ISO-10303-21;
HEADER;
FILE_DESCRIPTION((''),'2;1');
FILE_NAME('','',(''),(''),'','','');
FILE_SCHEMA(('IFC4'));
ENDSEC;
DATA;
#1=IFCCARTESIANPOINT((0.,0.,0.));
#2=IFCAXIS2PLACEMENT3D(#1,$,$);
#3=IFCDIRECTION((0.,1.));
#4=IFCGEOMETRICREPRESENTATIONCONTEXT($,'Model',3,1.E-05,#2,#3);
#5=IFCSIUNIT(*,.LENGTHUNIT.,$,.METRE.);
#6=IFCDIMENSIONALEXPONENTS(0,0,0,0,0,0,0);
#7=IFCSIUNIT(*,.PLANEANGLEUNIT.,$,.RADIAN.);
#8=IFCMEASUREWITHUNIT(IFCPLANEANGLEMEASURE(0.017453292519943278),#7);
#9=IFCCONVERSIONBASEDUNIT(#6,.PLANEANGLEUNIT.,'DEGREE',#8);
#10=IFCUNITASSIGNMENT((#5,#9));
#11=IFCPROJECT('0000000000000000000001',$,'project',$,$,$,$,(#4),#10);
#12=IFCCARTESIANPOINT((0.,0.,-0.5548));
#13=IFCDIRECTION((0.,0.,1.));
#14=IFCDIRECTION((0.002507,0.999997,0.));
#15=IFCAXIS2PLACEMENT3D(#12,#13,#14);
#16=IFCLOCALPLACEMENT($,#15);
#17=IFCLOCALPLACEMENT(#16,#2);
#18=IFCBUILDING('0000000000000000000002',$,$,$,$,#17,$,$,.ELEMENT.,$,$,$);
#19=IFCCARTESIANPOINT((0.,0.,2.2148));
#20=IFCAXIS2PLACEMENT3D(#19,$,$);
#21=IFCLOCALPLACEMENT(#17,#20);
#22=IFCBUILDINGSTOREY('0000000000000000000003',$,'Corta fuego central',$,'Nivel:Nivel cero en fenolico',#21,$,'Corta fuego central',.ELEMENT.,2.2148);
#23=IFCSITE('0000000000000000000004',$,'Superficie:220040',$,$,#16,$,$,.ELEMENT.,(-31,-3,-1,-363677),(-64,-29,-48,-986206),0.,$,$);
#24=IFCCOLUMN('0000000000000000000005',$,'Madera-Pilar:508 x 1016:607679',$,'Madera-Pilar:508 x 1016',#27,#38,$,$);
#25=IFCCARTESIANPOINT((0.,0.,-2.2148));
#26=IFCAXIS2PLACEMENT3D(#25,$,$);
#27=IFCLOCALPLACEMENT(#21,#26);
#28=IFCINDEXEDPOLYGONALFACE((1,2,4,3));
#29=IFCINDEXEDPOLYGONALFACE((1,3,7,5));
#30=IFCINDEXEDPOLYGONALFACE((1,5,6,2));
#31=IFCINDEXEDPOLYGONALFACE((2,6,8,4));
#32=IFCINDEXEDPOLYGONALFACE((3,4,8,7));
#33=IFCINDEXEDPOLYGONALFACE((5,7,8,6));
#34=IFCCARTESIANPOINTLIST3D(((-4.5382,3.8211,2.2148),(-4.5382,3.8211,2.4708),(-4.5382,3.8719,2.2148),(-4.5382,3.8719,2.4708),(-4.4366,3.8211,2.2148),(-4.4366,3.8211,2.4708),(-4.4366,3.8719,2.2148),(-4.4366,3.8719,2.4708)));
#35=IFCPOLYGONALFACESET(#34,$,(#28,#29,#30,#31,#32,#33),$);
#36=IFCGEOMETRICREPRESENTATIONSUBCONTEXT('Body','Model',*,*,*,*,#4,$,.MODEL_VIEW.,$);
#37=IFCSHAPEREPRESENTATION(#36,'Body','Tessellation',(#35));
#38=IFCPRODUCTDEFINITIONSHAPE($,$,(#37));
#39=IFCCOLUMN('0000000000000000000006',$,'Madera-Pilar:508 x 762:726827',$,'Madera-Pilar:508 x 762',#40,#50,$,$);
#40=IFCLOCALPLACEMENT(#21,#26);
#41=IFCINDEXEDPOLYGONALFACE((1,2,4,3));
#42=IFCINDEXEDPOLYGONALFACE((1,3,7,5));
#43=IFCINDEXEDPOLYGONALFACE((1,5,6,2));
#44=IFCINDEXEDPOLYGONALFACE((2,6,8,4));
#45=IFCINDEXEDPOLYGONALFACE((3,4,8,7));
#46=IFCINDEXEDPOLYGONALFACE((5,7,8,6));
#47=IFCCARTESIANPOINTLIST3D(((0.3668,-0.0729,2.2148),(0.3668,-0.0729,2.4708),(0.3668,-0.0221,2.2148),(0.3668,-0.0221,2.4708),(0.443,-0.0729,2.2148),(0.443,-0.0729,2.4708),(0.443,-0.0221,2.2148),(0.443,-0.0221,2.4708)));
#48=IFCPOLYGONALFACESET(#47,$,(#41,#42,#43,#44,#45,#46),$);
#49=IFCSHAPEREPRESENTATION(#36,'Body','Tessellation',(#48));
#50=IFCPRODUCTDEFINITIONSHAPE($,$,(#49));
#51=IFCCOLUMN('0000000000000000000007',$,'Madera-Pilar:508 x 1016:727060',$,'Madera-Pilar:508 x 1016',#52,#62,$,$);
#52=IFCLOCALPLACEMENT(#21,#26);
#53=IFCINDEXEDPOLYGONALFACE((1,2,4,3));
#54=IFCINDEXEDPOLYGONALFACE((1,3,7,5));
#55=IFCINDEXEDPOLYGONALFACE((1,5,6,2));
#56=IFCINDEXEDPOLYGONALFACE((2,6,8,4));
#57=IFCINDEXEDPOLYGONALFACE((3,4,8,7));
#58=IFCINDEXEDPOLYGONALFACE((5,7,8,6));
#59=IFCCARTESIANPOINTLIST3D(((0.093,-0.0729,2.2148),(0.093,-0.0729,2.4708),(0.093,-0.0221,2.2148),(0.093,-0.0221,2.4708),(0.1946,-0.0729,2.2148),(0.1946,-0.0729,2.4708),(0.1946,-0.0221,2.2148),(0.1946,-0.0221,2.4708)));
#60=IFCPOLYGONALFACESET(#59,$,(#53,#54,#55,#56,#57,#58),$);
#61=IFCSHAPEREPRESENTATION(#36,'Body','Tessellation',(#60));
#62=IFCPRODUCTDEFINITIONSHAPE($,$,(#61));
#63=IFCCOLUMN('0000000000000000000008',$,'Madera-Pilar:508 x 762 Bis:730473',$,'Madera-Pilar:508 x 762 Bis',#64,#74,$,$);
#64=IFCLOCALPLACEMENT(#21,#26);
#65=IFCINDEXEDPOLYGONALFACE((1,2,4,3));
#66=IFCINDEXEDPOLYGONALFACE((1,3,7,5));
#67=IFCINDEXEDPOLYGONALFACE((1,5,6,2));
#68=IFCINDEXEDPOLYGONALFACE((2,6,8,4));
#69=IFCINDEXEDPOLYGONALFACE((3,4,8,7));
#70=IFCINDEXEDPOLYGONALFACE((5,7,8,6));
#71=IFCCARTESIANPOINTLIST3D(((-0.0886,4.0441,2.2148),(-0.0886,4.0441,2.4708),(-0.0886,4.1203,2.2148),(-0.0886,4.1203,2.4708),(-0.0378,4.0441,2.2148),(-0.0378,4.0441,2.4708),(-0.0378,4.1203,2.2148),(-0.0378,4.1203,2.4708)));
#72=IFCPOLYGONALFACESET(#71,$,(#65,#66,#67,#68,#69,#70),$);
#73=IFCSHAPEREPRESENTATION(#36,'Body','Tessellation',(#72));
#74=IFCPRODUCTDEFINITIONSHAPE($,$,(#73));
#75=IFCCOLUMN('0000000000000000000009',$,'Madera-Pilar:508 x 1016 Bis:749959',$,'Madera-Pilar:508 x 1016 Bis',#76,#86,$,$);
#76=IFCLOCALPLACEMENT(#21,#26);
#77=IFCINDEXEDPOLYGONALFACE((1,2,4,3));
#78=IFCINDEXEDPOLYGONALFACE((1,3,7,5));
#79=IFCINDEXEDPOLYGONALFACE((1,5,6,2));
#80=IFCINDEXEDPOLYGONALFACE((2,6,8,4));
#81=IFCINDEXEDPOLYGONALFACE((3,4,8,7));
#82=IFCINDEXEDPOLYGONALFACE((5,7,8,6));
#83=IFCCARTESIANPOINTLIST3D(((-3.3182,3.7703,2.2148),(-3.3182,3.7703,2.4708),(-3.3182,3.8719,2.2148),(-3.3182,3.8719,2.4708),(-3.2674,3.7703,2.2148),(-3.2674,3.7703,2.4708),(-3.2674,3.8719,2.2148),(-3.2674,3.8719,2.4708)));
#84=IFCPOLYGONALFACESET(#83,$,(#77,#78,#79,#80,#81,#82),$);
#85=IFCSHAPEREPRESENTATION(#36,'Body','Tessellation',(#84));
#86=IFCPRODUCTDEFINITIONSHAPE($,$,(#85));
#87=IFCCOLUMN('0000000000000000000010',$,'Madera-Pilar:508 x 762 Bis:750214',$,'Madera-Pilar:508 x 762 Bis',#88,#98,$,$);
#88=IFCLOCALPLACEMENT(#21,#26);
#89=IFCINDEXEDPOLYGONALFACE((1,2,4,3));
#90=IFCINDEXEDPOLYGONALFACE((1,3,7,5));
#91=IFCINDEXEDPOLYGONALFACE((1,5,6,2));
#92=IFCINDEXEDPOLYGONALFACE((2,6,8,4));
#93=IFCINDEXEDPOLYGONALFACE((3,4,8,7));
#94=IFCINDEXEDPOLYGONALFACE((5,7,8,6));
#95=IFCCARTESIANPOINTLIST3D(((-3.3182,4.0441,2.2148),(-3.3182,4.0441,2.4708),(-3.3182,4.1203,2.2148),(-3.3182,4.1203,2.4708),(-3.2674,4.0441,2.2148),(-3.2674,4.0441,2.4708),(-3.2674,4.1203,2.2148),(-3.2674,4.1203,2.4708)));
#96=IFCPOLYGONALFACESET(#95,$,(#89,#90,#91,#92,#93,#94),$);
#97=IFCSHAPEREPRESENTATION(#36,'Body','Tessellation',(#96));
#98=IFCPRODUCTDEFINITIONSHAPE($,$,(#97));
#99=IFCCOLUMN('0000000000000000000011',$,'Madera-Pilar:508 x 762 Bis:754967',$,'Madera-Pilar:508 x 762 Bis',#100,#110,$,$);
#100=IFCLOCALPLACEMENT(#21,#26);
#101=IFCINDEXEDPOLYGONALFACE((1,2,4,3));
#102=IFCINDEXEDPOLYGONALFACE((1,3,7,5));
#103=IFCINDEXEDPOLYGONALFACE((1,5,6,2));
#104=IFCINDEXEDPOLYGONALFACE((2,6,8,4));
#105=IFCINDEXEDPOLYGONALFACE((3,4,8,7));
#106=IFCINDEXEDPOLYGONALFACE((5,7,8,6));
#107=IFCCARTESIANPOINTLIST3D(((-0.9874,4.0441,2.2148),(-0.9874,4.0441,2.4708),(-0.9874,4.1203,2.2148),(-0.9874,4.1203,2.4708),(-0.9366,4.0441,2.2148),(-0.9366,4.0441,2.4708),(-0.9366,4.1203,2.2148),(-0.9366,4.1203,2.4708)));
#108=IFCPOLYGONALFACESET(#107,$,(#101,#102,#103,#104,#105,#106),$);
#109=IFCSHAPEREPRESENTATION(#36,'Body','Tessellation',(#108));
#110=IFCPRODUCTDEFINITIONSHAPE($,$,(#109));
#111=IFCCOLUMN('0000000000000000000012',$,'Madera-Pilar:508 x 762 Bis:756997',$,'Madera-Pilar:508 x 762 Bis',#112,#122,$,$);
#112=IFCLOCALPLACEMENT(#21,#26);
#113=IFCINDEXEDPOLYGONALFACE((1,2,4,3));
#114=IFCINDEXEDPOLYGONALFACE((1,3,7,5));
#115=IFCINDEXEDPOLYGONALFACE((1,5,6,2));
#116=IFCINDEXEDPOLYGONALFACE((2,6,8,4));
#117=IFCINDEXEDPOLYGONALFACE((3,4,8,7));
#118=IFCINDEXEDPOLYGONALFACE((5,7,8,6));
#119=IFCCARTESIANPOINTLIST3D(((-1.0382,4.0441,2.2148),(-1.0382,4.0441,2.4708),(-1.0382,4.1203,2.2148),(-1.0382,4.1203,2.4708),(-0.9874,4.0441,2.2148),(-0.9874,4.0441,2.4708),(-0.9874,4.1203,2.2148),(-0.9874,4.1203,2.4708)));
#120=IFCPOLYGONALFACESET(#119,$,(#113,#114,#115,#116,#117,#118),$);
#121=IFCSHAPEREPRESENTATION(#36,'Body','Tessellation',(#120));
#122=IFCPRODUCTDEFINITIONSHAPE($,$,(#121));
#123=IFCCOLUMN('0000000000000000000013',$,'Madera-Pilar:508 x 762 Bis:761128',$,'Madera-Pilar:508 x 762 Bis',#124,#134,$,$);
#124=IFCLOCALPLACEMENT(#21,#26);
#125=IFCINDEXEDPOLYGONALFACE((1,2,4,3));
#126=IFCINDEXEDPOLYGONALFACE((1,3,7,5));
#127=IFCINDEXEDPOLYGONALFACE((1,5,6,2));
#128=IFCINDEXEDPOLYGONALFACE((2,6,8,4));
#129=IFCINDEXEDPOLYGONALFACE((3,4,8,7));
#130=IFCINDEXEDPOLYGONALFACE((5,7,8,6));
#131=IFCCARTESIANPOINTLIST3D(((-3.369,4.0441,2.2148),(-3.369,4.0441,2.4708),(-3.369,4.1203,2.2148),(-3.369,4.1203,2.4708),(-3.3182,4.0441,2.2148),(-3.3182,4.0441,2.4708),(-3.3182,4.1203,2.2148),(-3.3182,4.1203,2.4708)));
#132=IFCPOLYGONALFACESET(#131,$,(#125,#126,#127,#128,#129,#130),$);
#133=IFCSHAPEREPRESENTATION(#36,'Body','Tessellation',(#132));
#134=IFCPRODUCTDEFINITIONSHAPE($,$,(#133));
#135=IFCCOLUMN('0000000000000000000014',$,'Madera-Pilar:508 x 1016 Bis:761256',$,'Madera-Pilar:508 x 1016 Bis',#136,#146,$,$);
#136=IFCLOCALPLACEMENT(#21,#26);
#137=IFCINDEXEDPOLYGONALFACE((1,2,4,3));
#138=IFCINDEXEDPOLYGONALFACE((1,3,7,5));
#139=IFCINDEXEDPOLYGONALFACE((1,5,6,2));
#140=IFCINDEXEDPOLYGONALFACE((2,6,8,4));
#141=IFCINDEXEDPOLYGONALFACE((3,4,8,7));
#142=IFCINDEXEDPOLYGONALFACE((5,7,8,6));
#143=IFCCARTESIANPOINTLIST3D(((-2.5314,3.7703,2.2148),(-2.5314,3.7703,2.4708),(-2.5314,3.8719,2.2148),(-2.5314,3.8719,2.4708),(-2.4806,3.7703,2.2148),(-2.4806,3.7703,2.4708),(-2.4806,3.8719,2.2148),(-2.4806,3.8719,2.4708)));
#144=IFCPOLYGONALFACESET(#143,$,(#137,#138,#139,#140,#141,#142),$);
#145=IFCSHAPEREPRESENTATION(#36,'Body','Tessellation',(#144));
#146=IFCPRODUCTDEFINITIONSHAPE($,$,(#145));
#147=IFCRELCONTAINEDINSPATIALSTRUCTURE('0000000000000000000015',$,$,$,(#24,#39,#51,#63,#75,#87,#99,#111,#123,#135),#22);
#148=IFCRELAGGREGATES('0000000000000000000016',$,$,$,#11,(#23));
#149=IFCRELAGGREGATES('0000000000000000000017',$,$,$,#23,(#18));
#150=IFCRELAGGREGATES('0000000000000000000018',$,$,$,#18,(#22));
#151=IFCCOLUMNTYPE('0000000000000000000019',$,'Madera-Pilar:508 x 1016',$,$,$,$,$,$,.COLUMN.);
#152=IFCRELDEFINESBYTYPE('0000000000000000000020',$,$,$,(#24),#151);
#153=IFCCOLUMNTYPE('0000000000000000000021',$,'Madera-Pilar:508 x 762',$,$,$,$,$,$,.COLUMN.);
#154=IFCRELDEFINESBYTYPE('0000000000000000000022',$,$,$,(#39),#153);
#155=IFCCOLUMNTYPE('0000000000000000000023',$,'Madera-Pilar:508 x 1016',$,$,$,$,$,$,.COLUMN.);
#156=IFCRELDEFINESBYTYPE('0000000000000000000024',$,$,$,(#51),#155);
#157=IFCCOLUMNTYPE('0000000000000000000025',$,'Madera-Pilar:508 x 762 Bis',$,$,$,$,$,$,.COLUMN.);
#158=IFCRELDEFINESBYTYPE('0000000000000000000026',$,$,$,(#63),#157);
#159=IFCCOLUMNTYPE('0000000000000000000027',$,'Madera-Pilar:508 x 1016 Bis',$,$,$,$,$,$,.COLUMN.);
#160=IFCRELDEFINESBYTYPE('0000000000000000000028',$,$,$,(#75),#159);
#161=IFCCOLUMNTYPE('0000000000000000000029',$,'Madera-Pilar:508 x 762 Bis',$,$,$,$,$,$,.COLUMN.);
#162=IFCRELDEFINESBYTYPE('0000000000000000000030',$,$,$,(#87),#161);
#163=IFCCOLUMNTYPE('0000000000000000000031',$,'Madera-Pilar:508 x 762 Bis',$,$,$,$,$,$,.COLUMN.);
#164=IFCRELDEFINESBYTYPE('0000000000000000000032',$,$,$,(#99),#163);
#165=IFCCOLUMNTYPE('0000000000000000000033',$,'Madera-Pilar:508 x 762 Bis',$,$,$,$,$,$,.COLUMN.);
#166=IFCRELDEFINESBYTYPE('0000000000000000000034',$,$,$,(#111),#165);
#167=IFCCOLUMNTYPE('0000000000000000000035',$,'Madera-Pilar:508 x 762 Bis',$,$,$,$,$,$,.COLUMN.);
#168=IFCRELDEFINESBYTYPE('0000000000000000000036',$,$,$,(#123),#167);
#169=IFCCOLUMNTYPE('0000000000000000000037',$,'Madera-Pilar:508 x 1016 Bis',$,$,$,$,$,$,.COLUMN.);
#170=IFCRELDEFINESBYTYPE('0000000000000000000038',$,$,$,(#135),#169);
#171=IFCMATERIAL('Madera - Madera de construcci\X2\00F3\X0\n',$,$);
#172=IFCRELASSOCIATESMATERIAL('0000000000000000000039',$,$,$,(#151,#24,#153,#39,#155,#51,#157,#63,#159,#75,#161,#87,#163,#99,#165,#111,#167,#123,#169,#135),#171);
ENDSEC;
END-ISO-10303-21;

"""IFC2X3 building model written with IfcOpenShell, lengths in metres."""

from ifc_helpers import new_model, entity, si_unit, converted_unit, direction, frame, frame_2d, origin, place, context, subcontext, project, spatial, rectangle, extrude, source, transform, mapped, material, type_object, type_shapes, element, save


model = new_model("IFC2X3")

# Units and contexts
model_context = context("Model", 3, precision=1e-05, world=origin(), true_north=direction((0.0, 1.0)))
body_context = subcontext(model_context, "Body", "Model", "MODEL_VIEW")
ifc_project = project(units=[si_unit("LENGTHUNIT", "METRE"), converted_unit("PLANEANGLEUNIT", "DEGREE", entity("IfcPlaneAngleMeasure", 0.017453292519943278), si_unit("PLANEANGLEUNIT", "RADIAN"), dimensions=[0, 0, 0, 0, 0, 0, 0])], contexts=[model_context])

# Site, building, storey
site_placement = place(None, frame((0.0, 0.0, -0.5548), z_axis=(0.0, 0.0, 1.0), x_axis=(0.002507, 0.999997, 0.0)))
site = spatial("IfcSite", under=ifc_project, at=site_placement, Name="Superficie:220040", CompositionType="ELEMENT", RefLatitude=(-31, -3, -1, -363677), RefLongitude=(-64, -29, -48, -986206), RefElevation=0.0)
building_placement = place(site_placement, origin())
building = spatial("IfcBuilding", under=site, at=building_placement, CompositionType="ELEMENT")
storey_placement = place(building_placement, frame((0.0, 0.0, 2.2148)))
storey = spatial("IfcBuildingStorey", under=building, at=storey_placement, Name="Corta fuego central", ObjectType="Nivel:Nivel cero en fenolico", LongName="Corta fuego central", CompositionType="ELEMENT", Elevation=2.2148)

# Columns
ifc_material = material(Name="Madera - Madera de construcción")
column_type_1 = type_object("IfcColumnType", Name="Madera-Pilar:508 x 1016", PredefinedType="COLUMN", material=ifc_material)
shared_shape_1 = source(origin(), body_context, "Body", "SweptSolid", [
    extrude(rectangle(XDim=0.1016, YDim=0.0508, at=frame_2d((0.0, 0.0), x_axis=(1.0, 0.0))), frame((-4.4874, 3.8465, 2.2148), z_axis=(0.0, 0.0, 1.0), x_axis=(-1.0, 0.0, 0.0)), (0.0, 0.0, 1.0), 0.256),
])
type_shapes(column_type_1, [shared_shape_1])
column_1_placement = place(storey_placement, frame((0.0, 0.0, -2.2148)))
element("IfcColumn", 1, at=column_1_placement, inside=storey, type_object=column_type_1, material=ifc_material, Name="Madera-Pilar:508 x 1016:607679", ObjectType="Madera-Pilar:508 x 1016", context=body_context, shape_type="MappedRepresentation", body=[
    mapped(shared_shape_1, transform((0.0, 0.0, 0.0), scale=1.0)),
])
column_type_2 = type_object("IfcColumnType", Name="Madera-Pilar:508 x 762", PredefinedType="COLUMN", material=ifc_material)
shared_shape_2 = source(origin(), body_context, "Body", "SweptSolid", [
    extrude(rectangle(XDim=0.0762, YDim=0.0508, at=frame_2d((0.0, 0.0), x_axis=(1.0, 0.0))), frame((0.4049, -0.0475, 2.2148), z_axis=(0.0, 0.0, 1.0), x_axis=(-1.0, 0.0, 0.0)), (0.0, 0.0, 1.0), 0.256),
])
type_shapes(column_type_2, [shared_shape_2])
column_2_placement = place(storey_placement, frame((0.0, 0.0, -2.2148)))
element("IfcColumn", 2, at=column_2_placement, inside=storey, type_object=column_type_2, material=ifc_material, Name="Madera-Pilar:508 x 762:726827", ObjectType="Madera-Pilar:508 x 762", context=body_context, shape_type="MappedRepresentation", body=[
    mapped(shared_shape_2, transform((0.0, 0.0, 0.0), scale=1.0)),
])
column_type_3 = type_object("IfcColumnType", Name="Madera-Pilar:508 x 1016", PredefinedType="COLUMN", material=ifc_material)
shared_shape_3 = source(origin(), body_context, "Body", "SweptSolid", [
    extrude(rectangle(XDim=0.1016, YDim=0.0508, at=frame_2d((0.0, 0.0), x_axis=(1.0, 0.0))), frame((0.1438, -0.0475, 2.2148), z_axis=(0.0, 0.0, 1.0), x_axis=(-1.0, 0.0, 0.0)), (0.0, 0.0, 1.0), 0.256),
])
type_shapes(column_type_3, [shared_shape_3])
column_3_placement = place(storey_placement, frame((0.0, 0.0, -2.2148)))
element("IfcColumn", 3, at=column_3_placement, inside=storey, type_object=column_type_3, material=ifc_material, Name="Madera-Pilar:508 x 1016:727060", ObjectType="Madera-Pilar:508 x 1016", context=body_context, shape_type="MappedRepresentation", body=[
    mapped(shared_shape_3, transform((0.0, 0.0, 0.0), scale=1.0)),
])
column_type_4 = type_object("IfcColumnType", Name="Madera-Pilar:508 x 762 Bis", PredefinedType="COLUMN", material=ifc_material)
shared_shape_4 = source(origin(), body_context, "Body", "SweptSolid", [
    extrude(rectangle(XDim=0.0508, YDim=0.0762, at=frame_2d((0.0, 0.0), x_axis=(1.0, 0.0))), frame((-0.0632, 4.0822, 2.2148), z_axis=(0.0, 0.0, 1.0), x_axis=(-1.0, 0.0, 0.0)), (0.0, 0.0, 1.0), 0.256),
])
type_shapes(column_type_4, [shared_shape_4])
column_4_placement = place(storey_placement, frame((0.0, 0.0, -2.2148)))
element("IfcColumn", 4, at=column_4_placement, inside=storey, type_object=column_type_4, material=ifc_material, Name="Madera-Pilar:508 x 762 Bis:730473", ObjectType="Madera-Pilar:508 x 762 Bis", context=body_context, shape_type="MappedRepresentation", body=[
    mapped(shared_shape_4, transform((0.0, 0.0, 0.0), scale=1.0)),
])
column_type_5 = type_object("IfcColumnType", Name="Madera-Pilar:508 x 1016 Bis", PredefinedType="COLUMN", material=ifc_material)
shared_shape_5 = source(origin(), body_context, "Body", "SweptSolid", [
    extrude(rectangle(XDim=0.0508, YDim=0.1016, at=frame_2d((0.0, 0.0), x_axis=(1.0, 0.0))), frame((-3.2928, 3.8211, 2.2148), z_axis=(0.0, 0.0, 1.0), x_axis=(-1.0, 0.0, 0.0)), (0.0, 0.0, 1.0), 0.256),
])
type_shapes(column_type_5, [shared_shape_5])
column_5_placement = place(storey_placement, frame((0.0, 0.0, -2.2148)))
element("IfcColumn", 5, at=column_5_placement, inside=storey, type_object=column_type_5, material=ifc_material, Name="Madera-Pilar:508 x 1016 Bis:749959", ObjectType="Madera-Pilar:508 x 1016 Bis", context=body_context, shape_type="MappedRepresentation", body=[
    mapped(shared_shape_5, transform((0.0, 0.0, 0.0), scale=1.0)),
])
column_type_6 = type_object("IfcColumnType", Name="Madera-Pilar:508 x 762 Bis", PredefinedType="COLUMN", material=ifc_material)
shared_shape_6 = source(origin(), body_context, "Body", "SweptSolid", [
    extrude(rectangle(XDim=0.0508, YDim=0.0762, at=frame_2d((0.0, 0.0), x_axis=(1.0, 0.0))), frame((-3.2928, 4.0822, 2.2148), z_axis=(0.0, 0.0, 1.0), x_axis=(-1.0, 0.0, 0.0)), (0.0, 0.0, 1.0), 0.256),
])
type_shapes(column_type_6, [shared_shape_6])
column_6_placement = place(storey_placement, frame((0.0, 0.0, -2.2148)))
element("IfcColumn", 6, at=column_6_placement, inside=storey, type_object=column_type_6, material=ifc_material, Name="Madera-Pilar:508 x 762 Bis:750214", ObjectType="Madera-Pilar:508 x 762 Bis", context=body_context, shape_type="MappedRepresentation", body=[
    mapped(shared_shape_6, transform((0.0, 0.0, 0.0), scale=1.0)),
])
column_type_7 = type_object("IfcColumnType", Name="Madera-Pilar:508 x 762 Bis", PredefinedType="COLUMN", material=ifc_material)
shared_shape_7 = source(origin(), body_context, "Body", "SweptSolid", [
    extrude(rectangle(XDim=0.0508, YDim=0.0762, at=frame_2d((0.0, 0.0), x_axis=(1.0, 0.0))), frame((-0.962, 4.0822, 2.2148), z_axis=(0.0, 0.0, 1.0), x_axis=(-1.0, 0.0, 0.0)), (0.0, 0.0, 1.0), 0.256),
])
type_shapes(column_type_7, [shared_shape_7])
column_7_placement = place(storey_placement, frame((0.0, 0.0, -2.2148)))
element("IfcColumn", 7, at=column_7_placement, inside=storey, type_object=column_type_7, material=ifc_material, Name="Madera-Pilar:508 x 762 Bis:754967", ObjectType="Madera-Pilar:508 x 762 Bis", context=body_context, shape_type="MappedRepresentation", body=[
    mapped(shared_shape_7, transform((0.0, 0.0, 0.0), scale=1.0)),
])
column_type_8 = type_object("IfcColumnType", Name="Madera-Pilar:508 x 762 Bis", PredefinedType="COLUMN", material=ifc_material)
shared_shape_8 = source(origin(), body_context, "Body", "SweptSolid", [
    extrude(rectangle(XDim=0.0508, YDim=0.0762, at=frame_2d((0.0, 0.0), x_axis=(1.0, 0.0))), frame((-1.0128, 4.0822, 2.2148), z_axis=(0.0, 0.0, 1.0), x_axis=(-1.0, 0.0, 0.0)), (0.0, 0.0, 1.0), 0.256),
])
type_shapes(column_type_8, [shared_shape_8])
column_8_placement = place(storey_placement, frame((0.0, 0.0, -2.2148)))
element("IfcColumn", 8, at=column_8_placement, inside=storey, type_object=column_type_8, material=ifc_material, Name="Madera-Pilar:508 x 762 Bis:756997", ObjectType="Madera-Pilar:508 x 762 Bis", context=body_context, shape_type="MappedRepresentation", body=[
    mapped(shared_shape_8, transform((0.0, 0.0, 0.0), scale=1.0)),
])
column_type_9 = type_object("IfcColumnType", Name="Madera-Pilar:508 x 762 Bis", PredefinedType="COLUMN", material=ifc_material)
shared_shape_9 = source(origin(), body_context, "Body", "SweptSolid", [
    extrude(rectangle(XDim=0.0508, YDim=0.0762, at=frame_2d((0.0, 0.0), x_axis=(1.0, 0.0))), frame((-3.3436, 4.0822, 2.2148), z_axis=(0.0, 0.0, 1.0), x_axis=(-1.0, 0.0, 0.0)), (0.0, 0.0, 1.0), 0.256),
])
type_shapes(column_type_9, [shared_shape_9])
column_9_placement = place(storey_placement, frame((0.0, 0.0, -2.2148)))
element("IfcColumn", 9, at=column_9_placement, inside=storey, type_object=column_type_9, material=ifc_material, Name="Madera-Pilar:508 x 762 Bis:761128", ObjectType="Madera-Pilar:508 x 762 Bis", context=body_context, shape_type="MappedRepresentation", body=[
    mapped(shared_shape_9, transform((0.0, 0.0, 0.0), scale=1.0)),
])
column_type_10 = type_object("IfcColumnType", Name="Madera-Pilar:508 x 1016 Bis", PredefinedType="COLUMN", material=ifc_material)
shared_shape_10 = source(origin(), body_context, "Body", "SweptSolid", [
    extrude(rectangle(XDim=0.0508, YDim=0.1016, at=frame_2d((0.0, 0.0), x_axis=(1.0, 0.0))), frame((-2.506, 3.8211, 2.2148), z_axis=(0.0, 0.0, 1.0), x_axis=(-1.0, 0.0, 0.0)), (0.0, 0.0, 1.0), 0.256),
])
type_shapes(column_type_10, [shared_shape_10])
column_10_placement = place(storey_placement, frame((0.0, 0.0, -2.2148)))
element("IfcColumn", 10, at=column_10_placement, inside=storey, type_object=column_type_10, material=ifc_material, Name="Madera-Pilar:508 x 1016 Bis:761256", ObjectType="Madera-Pilar:508 x 1016 Bis", context=body_context, shape_type="MappedRepresentation", body=[
    mapped(shared_shape_10, transform((0.0, 0.0, 0.0), scale=1.0)),
])

save(model, "model.ifc")
